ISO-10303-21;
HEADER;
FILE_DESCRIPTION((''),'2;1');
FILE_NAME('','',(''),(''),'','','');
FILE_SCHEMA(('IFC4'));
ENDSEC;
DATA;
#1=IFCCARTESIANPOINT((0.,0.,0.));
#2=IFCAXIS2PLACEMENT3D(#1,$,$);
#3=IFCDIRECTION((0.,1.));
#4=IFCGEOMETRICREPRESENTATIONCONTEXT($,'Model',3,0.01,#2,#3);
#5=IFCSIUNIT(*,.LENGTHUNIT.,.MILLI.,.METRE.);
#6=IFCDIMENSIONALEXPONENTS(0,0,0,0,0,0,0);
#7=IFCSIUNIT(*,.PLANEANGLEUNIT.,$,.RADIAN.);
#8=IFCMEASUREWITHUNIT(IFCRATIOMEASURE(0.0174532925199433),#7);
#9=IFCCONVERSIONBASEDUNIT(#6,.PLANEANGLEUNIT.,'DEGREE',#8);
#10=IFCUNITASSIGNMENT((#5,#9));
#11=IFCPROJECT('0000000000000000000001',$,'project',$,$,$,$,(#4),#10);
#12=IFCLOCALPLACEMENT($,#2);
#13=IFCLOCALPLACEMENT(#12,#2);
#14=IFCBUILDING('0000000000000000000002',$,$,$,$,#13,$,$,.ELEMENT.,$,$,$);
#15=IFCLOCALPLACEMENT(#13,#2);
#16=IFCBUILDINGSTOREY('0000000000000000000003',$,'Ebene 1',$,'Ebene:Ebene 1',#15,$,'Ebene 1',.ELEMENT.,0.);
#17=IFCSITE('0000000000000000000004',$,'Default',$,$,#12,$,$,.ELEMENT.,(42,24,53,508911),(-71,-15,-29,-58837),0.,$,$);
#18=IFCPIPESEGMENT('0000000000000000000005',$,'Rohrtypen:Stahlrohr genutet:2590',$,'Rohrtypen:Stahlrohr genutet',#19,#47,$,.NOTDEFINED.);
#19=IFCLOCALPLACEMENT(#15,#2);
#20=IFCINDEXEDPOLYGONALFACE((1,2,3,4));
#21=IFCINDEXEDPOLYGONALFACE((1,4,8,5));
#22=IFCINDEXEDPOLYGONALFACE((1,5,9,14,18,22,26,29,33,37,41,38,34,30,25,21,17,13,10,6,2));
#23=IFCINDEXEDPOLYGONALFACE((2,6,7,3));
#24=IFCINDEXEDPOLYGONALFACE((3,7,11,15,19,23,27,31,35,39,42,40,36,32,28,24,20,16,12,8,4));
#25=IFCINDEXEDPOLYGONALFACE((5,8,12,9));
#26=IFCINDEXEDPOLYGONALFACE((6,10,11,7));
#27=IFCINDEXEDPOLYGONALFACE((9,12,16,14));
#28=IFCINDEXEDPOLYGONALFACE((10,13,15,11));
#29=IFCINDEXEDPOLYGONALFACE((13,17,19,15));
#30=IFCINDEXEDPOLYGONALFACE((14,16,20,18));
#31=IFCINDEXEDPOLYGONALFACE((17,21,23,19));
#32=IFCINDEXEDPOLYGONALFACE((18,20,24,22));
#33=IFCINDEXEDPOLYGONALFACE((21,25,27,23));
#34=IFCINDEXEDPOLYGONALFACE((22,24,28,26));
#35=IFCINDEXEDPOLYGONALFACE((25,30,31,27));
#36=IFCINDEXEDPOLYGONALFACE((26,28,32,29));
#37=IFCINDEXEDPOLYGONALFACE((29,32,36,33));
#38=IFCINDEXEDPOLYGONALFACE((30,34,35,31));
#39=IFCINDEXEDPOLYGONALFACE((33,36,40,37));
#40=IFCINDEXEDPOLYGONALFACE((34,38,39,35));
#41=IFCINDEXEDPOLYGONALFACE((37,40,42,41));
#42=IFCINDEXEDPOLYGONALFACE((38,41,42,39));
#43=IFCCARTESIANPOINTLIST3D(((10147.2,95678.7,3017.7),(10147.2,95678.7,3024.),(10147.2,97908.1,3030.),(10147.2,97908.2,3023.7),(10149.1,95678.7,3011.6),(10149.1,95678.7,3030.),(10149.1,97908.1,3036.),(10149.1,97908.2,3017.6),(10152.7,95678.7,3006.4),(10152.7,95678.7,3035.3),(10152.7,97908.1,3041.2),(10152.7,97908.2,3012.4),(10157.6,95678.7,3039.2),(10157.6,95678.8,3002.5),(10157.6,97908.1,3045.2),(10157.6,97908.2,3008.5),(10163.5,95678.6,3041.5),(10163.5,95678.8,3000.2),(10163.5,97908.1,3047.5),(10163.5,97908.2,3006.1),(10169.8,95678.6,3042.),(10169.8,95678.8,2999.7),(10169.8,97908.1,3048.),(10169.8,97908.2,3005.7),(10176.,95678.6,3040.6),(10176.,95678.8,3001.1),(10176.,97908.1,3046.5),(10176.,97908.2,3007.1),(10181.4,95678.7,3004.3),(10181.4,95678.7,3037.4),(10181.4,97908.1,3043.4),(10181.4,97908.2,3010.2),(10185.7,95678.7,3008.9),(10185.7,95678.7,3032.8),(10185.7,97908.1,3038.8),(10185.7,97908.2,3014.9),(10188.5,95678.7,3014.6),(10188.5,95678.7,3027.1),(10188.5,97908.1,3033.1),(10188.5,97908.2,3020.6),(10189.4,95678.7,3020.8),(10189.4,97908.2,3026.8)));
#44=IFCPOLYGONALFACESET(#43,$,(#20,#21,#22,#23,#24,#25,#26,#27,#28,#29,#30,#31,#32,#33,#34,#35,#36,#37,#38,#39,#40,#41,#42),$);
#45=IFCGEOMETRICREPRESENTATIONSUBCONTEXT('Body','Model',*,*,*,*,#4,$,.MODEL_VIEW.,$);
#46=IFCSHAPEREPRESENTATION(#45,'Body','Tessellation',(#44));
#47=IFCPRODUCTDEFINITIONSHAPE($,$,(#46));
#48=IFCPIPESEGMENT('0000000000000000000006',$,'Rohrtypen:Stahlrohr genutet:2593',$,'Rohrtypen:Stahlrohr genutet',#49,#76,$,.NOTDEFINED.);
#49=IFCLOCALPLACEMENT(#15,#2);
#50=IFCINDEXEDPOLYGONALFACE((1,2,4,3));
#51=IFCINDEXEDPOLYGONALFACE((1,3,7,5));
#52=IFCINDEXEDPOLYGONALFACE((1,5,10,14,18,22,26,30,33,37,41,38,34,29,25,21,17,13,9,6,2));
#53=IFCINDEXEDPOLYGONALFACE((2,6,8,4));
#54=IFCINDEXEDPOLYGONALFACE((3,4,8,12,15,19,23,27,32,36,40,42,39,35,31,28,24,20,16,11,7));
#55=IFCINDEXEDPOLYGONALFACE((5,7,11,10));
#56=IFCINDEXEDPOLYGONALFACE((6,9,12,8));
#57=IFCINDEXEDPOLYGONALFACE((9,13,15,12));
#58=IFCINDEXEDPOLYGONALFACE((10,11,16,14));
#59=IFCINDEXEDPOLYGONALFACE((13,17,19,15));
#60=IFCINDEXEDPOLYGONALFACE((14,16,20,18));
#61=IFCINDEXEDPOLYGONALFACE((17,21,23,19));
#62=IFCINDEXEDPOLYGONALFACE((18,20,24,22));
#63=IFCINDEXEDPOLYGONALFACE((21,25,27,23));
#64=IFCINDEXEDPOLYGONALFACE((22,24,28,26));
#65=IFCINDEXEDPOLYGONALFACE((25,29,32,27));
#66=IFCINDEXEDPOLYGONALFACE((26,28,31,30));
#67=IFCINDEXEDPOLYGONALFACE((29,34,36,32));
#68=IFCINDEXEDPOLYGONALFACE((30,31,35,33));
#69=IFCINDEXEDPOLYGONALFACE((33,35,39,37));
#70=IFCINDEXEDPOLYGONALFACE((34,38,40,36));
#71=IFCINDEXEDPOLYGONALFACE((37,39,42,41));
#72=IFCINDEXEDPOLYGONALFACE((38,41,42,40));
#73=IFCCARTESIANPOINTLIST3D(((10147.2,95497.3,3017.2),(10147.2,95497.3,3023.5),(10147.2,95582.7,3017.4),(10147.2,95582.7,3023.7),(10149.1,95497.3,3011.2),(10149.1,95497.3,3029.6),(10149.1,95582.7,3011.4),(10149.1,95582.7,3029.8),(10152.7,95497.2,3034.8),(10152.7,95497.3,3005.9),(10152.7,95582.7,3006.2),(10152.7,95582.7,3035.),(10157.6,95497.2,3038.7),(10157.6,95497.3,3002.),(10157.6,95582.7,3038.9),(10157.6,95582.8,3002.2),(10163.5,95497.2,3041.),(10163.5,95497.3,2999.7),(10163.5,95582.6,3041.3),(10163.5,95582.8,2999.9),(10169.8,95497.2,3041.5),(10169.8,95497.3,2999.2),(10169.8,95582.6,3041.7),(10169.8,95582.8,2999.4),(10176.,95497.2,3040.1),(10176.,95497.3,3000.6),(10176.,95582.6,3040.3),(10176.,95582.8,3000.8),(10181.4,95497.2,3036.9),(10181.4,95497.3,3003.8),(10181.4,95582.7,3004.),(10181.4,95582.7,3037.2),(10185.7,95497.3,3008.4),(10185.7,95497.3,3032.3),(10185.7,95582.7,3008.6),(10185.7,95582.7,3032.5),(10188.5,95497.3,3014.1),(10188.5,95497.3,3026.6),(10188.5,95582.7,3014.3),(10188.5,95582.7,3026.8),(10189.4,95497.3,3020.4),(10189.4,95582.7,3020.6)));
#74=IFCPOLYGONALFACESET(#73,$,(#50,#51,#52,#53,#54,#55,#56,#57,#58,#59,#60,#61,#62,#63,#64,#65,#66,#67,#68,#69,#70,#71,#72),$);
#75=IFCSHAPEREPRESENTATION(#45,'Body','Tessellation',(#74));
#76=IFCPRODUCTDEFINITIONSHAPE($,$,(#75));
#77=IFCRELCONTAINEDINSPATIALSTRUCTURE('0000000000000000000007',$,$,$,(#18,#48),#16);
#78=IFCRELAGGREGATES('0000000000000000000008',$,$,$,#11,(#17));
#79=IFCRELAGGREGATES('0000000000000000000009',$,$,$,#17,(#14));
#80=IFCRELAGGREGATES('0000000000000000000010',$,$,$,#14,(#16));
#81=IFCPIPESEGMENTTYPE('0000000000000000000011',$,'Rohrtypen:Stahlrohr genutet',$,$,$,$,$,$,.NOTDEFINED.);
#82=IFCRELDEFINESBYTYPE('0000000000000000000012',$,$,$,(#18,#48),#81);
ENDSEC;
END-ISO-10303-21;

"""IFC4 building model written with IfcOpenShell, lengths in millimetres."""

from ifc_helpers import new_model, entity, si_unit, converted_unit, direction, frame, frame_2d, origin, origin_2d_with_axis, place, context, subcontext, project, spatial, circle, extrude, type_object, element, save


model = new_model("IFC4")

# Units and contexts
model_context = context("Model", 3, precision=0.01, world=origin(), true_north=direction((0.0, 1.0)))
body_context = subcontext(model_context, "Body", "Model", "MODEL_VIEW")
ifc_project = project(units=[si_unit("LENGTHUNIT", "METRE", prefix="MILLI"), converted_unit("PLANEANGLEUNIT", "DEGREE", entity("IfcRatioMeasure", 0.0174532925199433), si_unit("PLANEANGLEUNIT", "RADIAN"), dimensions=[0, 0, 0, 0, 0, 0, 0])], contexts=[model_context])

# Site, building, storey
site_placement = place(None, origin())
site = spatial("IfcSite", under=ifc_project, at=site_placement, Name="Default", CompositionType="ELEMENT", RefLatitude=(42, 24, 53, 508911), RefLongitude=(-71, -15, -29, -58837), RefElevation=0.0)
building_placement = place(site_placement, origin())
building = spatial("IfcBuilding", under=site, at=building_placement, CompositionType="ELEMENT")
storey_placement = place(building_placement, origin())
storey = spatial("IfcBuildingStorey", under=building, at=storey_placement, Name="Ebene 1", ObjectType="Ebene:Ebene 1", LongName="Ebene 1", CompositionType="ELEMENT", Elevation=0.0)

# Pipe segments
pipe_segment_type = type_object("IfcPipeSegmentType", Name="Rohrtypen:Stahlrohr genutet", PredefinedType="NOTDEFINED")
pipe_segment_1_placement = place(storey_placement, frame((10145.4, 95678.6, 2998.0)))
element("IfcPipeSegment", 1, at=pipe_segment_1_placement, inside=storey, type_object=pipe_segment_type, Name="Rohrtypen:Stahlrohr genutet:2590", ObjectType="Rohrtypen:Stahlrohr genutet", PredefinedType="NOTDEFINED", context=body_context, shape_type="SweptSolid", body=[
    extrude(circle(Radius=21.2, at=origin_2d_with_axis()), frame((22.8, 0.1, 22.8), z_axis=(0.0, 0.999996, 0.002678), x_axis=(1.0, 0.0, 0.0)), (0.0, 0.0, 1.0), 2229.5),
])
pipe_segment_2_placement = place(storey_placement, frame((10145.4, 95497.2, 2997.6)))
element("IfcPipeSegment", 2, at=pipe_segment_2_placement, inside=storey, type_object=pipe_segment_type, Name="Rohrtypen:Stahlrohr genutet:2593", ObjectType="Rohrtypen:Stahlrohr genutet", PredefinedType="NOTDEFINED", context=body_context, shape_type="SweptSolid", body=[
    extrude(circle(Radius=21.2, at=frame_2d((0.0, 0.0), x_axis=(1.0, 0.0))), frame((22.8, 0.1, 22.8), z_axis=(0.0, 0.999996, 0.002678), x_axis=(1.0, 0.0, 0.0)), (0.0, 0.0, 1.0), 85.4),
])

save(model, "model.ifc")
